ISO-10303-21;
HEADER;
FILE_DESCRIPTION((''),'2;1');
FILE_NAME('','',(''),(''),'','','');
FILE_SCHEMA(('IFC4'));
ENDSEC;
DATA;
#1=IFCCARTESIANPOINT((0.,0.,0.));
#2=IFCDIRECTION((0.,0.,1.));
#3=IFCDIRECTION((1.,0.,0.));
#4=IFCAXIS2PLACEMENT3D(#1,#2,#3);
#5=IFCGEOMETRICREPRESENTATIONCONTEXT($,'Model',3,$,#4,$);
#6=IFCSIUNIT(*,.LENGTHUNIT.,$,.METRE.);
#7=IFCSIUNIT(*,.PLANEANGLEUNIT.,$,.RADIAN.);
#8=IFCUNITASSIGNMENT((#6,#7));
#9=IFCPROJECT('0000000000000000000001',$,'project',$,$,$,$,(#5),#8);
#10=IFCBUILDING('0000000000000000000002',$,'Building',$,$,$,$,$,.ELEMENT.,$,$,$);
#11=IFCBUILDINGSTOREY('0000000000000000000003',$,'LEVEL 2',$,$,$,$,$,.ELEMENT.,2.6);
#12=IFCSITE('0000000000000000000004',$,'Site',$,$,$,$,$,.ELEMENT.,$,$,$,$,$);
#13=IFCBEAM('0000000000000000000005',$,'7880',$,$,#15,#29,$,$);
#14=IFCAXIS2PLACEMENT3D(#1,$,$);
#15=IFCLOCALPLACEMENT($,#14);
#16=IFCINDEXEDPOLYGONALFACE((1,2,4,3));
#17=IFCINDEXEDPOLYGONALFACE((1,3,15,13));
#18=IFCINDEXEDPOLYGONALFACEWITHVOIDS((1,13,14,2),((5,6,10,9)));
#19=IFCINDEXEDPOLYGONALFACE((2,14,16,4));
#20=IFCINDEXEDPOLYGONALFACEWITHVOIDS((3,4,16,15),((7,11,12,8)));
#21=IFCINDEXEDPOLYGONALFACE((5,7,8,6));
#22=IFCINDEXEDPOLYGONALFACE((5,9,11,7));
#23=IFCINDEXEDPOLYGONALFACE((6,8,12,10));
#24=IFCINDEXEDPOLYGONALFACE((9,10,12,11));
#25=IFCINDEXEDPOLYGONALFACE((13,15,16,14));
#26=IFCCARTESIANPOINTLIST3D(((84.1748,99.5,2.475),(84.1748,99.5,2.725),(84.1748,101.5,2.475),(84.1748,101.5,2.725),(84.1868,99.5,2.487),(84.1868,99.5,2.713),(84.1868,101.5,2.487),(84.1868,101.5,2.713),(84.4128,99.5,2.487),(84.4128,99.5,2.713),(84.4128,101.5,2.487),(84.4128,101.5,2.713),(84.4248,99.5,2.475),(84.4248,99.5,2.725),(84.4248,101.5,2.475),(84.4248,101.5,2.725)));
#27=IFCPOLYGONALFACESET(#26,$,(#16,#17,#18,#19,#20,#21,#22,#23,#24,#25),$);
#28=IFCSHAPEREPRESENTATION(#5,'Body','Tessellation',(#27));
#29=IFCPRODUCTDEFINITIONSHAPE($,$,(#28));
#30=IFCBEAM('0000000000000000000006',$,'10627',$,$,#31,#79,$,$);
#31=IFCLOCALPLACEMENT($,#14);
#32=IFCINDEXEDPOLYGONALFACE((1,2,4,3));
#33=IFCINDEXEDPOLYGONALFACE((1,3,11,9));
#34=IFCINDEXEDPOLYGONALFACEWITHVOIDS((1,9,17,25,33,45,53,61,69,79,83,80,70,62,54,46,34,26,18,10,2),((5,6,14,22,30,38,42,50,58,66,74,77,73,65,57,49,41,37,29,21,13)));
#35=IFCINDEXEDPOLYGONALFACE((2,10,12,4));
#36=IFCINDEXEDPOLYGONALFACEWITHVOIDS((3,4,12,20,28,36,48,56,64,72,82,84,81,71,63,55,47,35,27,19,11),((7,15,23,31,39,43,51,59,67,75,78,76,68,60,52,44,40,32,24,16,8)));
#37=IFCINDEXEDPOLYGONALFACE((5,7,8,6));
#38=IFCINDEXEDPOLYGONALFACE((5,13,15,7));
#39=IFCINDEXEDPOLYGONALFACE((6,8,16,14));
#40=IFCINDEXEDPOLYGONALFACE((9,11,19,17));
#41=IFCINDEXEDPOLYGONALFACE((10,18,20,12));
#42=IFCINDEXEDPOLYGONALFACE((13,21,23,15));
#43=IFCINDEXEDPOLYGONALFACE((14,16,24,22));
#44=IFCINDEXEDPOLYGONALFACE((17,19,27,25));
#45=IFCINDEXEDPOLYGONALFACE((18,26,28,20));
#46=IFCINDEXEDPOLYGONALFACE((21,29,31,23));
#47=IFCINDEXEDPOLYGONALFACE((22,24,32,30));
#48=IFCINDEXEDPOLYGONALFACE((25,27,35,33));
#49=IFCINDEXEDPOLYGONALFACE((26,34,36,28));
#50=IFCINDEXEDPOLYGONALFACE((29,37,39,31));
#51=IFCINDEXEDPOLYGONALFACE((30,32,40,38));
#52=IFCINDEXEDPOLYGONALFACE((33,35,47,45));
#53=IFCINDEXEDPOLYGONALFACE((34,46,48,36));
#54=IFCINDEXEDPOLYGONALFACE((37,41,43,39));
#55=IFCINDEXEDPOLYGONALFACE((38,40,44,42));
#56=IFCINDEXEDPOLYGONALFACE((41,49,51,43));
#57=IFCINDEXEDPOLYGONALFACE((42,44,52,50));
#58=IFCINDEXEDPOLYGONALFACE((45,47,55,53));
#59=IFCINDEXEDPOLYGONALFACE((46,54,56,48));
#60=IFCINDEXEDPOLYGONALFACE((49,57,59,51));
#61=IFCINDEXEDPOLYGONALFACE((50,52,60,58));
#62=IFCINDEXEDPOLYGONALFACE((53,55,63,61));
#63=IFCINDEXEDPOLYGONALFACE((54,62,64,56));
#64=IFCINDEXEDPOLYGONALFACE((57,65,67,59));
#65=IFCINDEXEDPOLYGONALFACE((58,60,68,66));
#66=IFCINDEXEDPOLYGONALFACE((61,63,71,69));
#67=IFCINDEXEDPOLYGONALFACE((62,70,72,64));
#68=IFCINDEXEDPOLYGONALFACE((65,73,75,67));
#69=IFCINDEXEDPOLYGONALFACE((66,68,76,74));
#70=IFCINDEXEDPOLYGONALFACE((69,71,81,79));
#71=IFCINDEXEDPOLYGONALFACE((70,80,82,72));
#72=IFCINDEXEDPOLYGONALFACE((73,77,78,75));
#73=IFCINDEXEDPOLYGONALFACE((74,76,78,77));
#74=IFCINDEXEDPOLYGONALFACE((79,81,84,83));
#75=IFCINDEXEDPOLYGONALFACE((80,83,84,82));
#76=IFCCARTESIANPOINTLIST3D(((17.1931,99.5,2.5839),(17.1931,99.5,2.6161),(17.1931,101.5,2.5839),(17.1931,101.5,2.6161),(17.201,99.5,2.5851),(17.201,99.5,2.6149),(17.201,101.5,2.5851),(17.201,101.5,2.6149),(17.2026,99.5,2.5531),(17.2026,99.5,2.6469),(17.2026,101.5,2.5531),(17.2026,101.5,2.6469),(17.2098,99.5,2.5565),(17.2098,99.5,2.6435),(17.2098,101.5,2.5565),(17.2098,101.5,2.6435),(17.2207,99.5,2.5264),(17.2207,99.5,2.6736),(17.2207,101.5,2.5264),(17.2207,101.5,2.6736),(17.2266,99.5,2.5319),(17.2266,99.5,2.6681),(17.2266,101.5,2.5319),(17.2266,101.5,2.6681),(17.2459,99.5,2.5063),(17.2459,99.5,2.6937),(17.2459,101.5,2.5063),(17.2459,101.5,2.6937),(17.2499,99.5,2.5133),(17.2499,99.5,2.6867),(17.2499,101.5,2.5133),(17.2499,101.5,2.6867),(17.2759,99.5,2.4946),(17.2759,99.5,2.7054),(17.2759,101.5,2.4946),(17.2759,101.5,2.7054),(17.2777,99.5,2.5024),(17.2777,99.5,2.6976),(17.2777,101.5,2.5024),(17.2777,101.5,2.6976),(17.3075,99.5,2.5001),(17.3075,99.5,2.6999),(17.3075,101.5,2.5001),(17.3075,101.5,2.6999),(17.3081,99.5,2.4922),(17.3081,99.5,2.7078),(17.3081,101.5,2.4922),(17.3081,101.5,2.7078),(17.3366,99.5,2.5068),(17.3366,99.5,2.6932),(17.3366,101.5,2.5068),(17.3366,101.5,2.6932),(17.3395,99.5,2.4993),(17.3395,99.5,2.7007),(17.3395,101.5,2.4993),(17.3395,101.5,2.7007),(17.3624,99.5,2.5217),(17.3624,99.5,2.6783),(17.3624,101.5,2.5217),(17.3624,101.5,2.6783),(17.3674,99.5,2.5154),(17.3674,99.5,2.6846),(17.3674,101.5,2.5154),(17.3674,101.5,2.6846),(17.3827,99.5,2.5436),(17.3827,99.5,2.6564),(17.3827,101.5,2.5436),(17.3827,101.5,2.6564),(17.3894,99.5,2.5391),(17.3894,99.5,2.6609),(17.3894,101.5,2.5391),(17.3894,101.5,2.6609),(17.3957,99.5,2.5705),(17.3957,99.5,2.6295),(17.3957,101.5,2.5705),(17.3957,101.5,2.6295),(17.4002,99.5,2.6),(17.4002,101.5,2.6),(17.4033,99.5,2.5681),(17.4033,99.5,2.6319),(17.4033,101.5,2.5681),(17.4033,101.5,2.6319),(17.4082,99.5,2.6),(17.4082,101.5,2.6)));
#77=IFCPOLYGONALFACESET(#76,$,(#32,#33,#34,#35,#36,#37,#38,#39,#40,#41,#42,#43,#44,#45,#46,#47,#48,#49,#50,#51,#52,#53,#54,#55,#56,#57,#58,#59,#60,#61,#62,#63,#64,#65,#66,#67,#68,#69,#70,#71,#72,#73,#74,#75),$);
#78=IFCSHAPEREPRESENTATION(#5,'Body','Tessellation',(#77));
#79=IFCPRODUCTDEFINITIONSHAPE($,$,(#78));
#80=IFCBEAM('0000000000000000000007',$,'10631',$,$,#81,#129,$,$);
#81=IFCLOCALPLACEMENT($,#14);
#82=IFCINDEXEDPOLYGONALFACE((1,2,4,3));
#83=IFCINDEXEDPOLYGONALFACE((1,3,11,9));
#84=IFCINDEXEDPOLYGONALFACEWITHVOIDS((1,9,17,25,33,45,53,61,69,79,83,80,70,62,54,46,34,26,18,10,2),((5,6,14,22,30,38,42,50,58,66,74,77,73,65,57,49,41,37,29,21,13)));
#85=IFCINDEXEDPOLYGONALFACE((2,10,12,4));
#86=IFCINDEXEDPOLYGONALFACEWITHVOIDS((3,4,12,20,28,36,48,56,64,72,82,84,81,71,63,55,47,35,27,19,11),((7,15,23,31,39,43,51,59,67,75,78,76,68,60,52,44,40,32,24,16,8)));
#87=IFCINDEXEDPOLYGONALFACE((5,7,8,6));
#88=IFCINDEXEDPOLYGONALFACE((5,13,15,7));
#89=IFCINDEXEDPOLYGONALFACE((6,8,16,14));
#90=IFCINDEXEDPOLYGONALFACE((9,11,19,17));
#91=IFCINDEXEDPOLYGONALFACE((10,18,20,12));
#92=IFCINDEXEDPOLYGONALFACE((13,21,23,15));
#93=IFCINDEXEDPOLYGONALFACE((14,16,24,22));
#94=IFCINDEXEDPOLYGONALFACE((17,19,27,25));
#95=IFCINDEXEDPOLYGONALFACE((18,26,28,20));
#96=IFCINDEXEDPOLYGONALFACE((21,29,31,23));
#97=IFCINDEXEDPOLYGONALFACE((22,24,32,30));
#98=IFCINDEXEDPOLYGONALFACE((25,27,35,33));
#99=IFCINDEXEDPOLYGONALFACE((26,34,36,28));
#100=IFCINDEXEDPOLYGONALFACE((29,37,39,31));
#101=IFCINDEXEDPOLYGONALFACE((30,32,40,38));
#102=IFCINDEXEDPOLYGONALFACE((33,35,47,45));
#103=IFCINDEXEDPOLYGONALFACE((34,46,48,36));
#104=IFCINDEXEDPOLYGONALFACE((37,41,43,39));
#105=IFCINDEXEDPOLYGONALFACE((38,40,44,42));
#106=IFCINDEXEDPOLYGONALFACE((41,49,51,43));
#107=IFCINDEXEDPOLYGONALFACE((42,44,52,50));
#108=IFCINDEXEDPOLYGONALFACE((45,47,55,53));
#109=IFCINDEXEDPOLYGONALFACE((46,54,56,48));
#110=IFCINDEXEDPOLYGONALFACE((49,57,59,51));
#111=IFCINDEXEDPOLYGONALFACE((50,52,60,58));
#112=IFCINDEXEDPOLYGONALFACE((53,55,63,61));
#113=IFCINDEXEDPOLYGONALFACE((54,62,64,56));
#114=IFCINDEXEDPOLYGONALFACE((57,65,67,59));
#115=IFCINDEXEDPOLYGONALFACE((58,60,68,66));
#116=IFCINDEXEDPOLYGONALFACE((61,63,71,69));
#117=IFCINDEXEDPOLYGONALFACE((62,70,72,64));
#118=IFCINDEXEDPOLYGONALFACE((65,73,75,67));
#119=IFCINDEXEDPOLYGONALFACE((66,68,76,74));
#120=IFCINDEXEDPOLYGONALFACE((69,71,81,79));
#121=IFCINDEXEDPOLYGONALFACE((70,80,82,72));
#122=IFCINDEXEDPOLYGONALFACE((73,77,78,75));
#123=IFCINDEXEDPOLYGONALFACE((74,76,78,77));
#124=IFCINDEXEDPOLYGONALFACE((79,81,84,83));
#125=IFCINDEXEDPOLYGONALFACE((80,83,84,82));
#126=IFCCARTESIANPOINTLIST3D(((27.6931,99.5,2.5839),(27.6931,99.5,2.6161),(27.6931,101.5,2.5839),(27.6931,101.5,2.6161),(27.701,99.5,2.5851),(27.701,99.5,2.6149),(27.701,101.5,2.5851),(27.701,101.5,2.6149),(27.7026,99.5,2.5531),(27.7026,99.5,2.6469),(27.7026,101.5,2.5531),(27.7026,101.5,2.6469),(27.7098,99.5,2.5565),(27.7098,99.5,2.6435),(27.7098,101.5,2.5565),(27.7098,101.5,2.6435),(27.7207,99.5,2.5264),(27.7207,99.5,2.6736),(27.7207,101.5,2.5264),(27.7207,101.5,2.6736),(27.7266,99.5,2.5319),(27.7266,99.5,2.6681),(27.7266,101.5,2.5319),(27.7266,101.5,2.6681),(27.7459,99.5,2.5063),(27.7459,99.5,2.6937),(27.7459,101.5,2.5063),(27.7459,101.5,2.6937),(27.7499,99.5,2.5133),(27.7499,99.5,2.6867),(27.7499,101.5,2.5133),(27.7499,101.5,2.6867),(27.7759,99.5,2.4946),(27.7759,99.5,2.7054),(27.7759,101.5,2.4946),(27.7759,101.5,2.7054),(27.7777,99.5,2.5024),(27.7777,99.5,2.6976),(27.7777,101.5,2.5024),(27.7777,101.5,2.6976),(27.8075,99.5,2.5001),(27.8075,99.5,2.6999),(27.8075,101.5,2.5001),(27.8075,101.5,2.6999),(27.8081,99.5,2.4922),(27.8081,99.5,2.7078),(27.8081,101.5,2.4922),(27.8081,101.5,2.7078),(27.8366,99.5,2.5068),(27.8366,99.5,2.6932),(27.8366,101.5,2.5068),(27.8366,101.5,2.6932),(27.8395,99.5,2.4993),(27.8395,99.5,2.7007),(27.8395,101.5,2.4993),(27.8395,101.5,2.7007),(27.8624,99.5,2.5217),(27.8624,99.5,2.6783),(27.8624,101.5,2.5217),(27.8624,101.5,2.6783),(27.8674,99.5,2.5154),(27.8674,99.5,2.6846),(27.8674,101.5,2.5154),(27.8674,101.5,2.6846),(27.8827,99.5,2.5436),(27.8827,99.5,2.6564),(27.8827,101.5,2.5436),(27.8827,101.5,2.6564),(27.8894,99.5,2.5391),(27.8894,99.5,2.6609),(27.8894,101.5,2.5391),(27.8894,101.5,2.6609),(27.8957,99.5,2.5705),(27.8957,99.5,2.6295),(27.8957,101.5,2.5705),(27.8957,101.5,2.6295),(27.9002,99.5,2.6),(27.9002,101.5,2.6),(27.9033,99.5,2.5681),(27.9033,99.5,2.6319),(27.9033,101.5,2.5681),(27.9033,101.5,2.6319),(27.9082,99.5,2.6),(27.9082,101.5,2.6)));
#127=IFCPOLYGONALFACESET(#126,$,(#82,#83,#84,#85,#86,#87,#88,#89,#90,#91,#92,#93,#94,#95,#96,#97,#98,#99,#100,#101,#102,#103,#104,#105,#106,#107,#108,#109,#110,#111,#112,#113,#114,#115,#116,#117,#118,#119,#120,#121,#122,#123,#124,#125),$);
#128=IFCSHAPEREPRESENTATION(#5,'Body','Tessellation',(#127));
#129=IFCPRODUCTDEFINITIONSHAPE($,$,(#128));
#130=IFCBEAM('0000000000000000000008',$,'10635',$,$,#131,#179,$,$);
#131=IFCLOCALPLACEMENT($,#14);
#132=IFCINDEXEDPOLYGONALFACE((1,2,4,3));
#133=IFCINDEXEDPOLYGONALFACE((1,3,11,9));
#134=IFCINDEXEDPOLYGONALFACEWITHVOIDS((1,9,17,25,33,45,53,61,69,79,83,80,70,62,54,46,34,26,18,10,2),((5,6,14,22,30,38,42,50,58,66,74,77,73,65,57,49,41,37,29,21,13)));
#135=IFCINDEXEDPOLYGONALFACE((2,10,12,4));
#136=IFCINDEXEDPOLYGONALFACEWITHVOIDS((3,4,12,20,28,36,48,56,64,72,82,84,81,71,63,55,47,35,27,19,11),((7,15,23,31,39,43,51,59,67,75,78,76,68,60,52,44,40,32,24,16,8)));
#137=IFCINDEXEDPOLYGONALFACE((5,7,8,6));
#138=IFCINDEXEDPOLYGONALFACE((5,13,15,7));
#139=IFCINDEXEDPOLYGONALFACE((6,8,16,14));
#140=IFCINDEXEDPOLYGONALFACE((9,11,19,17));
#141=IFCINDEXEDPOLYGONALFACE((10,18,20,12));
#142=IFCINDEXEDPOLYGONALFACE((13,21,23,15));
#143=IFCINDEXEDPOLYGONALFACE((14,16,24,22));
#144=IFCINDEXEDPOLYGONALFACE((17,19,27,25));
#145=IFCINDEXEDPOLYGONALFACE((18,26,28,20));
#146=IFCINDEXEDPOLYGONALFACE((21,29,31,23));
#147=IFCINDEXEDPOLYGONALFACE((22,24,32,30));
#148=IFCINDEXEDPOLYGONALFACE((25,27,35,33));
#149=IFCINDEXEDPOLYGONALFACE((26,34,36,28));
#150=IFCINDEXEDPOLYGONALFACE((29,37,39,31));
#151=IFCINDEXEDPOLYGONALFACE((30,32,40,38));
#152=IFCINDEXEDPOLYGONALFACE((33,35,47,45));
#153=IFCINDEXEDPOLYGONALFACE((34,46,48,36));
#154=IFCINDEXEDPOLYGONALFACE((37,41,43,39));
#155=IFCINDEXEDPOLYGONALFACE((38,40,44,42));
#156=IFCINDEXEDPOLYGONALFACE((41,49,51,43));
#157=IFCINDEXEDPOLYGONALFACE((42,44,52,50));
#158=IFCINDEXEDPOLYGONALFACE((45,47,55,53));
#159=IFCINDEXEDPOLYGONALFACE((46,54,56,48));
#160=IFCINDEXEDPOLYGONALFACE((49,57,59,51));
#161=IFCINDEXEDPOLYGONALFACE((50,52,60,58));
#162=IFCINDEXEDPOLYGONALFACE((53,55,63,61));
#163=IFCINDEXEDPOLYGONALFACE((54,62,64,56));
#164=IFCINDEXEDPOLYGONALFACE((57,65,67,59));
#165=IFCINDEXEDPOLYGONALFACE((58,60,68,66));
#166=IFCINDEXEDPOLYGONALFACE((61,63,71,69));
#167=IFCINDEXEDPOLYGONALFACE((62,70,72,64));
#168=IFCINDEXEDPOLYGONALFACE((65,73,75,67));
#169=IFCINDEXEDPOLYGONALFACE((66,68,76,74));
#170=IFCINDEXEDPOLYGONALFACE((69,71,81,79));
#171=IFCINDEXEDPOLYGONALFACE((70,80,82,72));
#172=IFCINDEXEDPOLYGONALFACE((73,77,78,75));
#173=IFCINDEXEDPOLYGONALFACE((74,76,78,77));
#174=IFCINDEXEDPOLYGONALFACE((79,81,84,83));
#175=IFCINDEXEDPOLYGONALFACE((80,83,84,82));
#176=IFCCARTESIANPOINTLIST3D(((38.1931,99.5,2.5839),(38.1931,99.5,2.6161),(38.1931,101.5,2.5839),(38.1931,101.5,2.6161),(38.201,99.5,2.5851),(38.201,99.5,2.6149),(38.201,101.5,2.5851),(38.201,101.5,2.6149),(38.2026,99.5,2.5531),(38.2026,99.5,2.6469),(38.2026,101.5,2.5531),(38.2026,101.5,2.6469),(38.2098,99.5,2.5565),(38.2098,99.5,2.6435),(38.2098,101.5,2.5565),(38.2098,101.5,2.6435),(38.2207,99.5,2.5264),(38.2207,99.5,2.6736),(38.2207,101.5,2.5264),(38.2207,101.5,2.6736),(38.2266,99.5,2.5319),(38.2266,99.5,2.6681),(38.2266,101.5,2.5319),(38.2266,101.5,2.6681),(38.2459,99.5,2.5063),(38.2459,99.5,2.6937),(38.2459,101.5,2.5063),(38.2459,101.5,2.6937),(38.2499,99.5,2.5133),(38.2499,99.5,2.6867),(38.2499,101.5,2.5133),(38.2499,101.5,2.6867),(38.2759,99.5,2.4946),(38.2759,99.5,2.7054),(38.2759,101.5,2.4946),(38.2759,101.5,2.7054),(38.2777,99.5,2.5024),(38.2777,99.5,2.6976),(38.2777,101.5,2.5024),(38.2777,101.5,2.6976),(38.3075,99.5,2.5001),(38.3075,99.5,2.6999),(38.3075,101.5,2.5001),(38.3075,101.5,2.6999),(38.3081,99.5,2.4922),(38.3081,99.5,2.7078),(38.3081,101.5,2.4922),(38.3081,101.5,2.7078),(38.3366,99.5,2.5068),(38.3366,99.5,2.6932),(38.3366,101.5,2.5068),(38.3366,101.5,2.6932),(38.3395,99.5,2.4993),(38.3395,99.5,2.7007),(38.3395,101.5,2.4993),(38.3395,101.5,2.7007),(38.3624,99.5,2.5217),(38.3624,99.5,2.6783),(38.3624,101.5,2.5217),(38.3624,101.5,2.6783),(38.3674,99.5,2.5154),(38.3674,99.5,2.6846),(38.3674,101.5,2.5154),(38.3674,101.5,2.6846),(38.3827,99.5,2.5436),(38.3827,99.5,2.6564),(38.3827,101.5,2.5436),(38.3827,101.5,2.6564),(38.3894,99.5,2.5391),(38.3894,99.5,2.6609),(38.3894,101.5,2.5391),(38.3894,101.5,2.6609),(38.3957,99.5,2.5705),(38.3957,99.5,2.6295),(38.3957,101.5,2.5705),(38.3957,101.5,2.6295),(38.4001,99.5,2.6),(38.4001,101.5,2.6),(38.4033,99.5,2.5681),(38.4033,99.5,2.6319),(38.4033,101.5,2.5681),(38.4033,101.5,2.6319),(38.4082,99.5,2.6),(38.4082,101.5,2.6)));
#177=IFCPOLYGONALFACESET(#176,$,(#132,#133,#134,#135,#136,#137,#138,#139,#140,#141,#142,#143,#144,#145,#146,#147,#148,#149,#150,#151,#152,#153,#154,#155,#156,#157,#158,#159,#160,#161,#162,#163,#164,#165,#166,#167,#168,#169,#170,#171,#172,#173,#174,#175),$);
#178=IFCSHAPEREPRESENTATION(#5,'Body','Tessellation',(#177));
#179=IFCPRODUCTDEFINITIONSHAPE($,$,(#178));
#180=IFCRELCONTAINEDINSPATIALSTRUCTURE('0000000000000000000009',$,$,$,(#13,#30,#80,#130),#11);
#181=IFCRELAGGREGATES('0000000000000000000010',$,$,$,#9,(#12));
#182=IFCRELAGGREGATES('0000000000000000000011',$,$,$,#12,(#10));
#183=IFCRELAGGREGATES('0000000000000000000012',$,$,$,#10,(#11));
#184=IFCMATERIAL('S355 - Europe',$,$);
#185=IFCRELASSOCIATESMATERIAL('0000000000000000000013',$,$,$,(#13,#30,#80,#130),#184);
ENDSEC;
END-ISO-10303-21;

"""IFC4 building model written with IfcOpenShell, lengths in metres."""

from ifc_helpers import new_model, si_unit, frame, origin_with_axes, origin_2d_with_axis, place, context, project, spatial, hollow_rectangle, hollow_circle, extrude, material, material_profile, profile_set, profile_usage, element, save


model = new_model("IFC4")

# Units and contexts
model_context = context("Model", 3, world=origin_with_axes())
ifc_project = project(units=[si_unit("LENGTHUNIT", "METRE"), si_unit("PLANEANGLEUNIT", "RADIAN")], contexts=[model_context])

# Site, building, storey
site = spatial("IfcSite", under=ifc_project, Name="Site", CompositionType="ELEMENT")
building = spatial("IfcBuilding", under=site, Name="Building", CompositionType="ELEMENT")
storey = spatial("IfcBuildingStorey", under=building, Name="LEVEL 2", CompositionType="ELEMENT", Elevation=2.6)

# Shared definitions
ifc_material = material(Name="S355 - Europe")

# Beams
ifc_material_profile_1 = material_profile(ifc_material, hollow_rectangle(XDim=0.25, YDim=0.25, WallThickness=0.012, at=origin_2d_with_axis()))
ifc_profile_set_1 = profile_set([ifc_material_profile_1])
ifc_profile_usage_1 = profile_usage(ifc_profile_set_1, cardinal=10)
beam_1_placement = place(None, frame((84.2998, 101.5, 2.6), z_axis=(0.0, -1.0, 0.0), x_axis=(1.0, 0.0, 0.0)))
element("IfcBeam", 1, at=beam_1_placement, inside=storey, material=ifc_profile_usage_1, Name="7880", context=model_context, shape_type="SweptSolid", body=[
    extrude(hollow_rectangle(XDim=0.25, YDim=0.25, WallThickness=0.012, at=origin_2d_with_axis()), origin_with_axes(), (0.0, 0.0, 1.0), 2.0),
])
ifc_material_profile_2 = material_profile(ifc_material, hollow_circle(Radius=0.1081, WallThickness=0.008, at=origin_2d_with_axis()))
ifc_profile_set_2 = profile_set([ifc_material_profile_2])
ifc_profile_usage_2 = profile_usage(ifc_profile_set_2, cardinal=10)
beam_2_placement = place(None, frame((17.3, 101.5, 2.6), z_axis=(0.0, -1.0, 0.0), x_axis=(1.0, 0.0, 0.0)))
element("IfcBeam", 2, at=beam_2_placement, inside=storey, material=ifc_profile_usage_2, Name="10627", context=model_context, shape_type="SweptSolid", body=[
    extrude(hollow_circle(Radius=0.1081, WallThickness=0.008, at=origin_2d_with_axis()), origin_with_axes(), (0.0, 0.0, 1.0), 2.0),
])
ifc_material_profile_3 = material_profile(ifc_material, hollow_circle(Radius=0.1081, WallThickness=0.008, at=origin_2d_with_axis()))
ifc_profile_set_3 = profile_set([ifc_material_profile_3])
ifc_profile_usage_3 = profile_usage(ifc_profile_set_3, cardinal=10)
beam_3_placement = place(None, frame((27.8, 101.5, 2.6), z_axis=(0.0, -1.0, 0.0), x_axis=(1.0, 0.0, 0.0)))
element("IfcBeam", 3, at=beam_3_placement, inside=storey, material=ifc_profile_usage_3, Name="10631", context=model_context, shape_type="SweptSolid", body=[
    extrude(hollow_circle(Radius=0.1081, WallThickness=0.008, at=origin_2d_with_axis()), origin_with_axes(), (0.0, 0.0, 1.0), 2.0),
])
ifc_material_profile_4 = material_profile(ifc_material, hollow_circle(Radius=0.1081, WallThickness=0.008, at=origin_2d_with_axis()))
ifc_profile_set_4 = profile_set([ifc_material_profile_4])
ifc_profile_usage_4 = profile_usage(ifc_profile_set_4, cardinal=10)
beam_4_placement = place(None, frame((38.3, 101.5, 2.6), z_axis=(0.0, -1.0, 0.0), x_axis=(1.0, 0.0, 0.0)))
element("IfcBeam", 4, at=beam_4_placement, inside=storey, material=ifc_profile_usage_4, Name="10635", context=model_context, shape_type="SweptSolid", body=[
    extrude(hollow_circle(Radius=0.1081, WallThickness=0.008, at=origin_2d_with_axis()), origin_with_axes(), (0.0, 0.0, 1.0), 2.0),
])

save(model, "model.ifc")
